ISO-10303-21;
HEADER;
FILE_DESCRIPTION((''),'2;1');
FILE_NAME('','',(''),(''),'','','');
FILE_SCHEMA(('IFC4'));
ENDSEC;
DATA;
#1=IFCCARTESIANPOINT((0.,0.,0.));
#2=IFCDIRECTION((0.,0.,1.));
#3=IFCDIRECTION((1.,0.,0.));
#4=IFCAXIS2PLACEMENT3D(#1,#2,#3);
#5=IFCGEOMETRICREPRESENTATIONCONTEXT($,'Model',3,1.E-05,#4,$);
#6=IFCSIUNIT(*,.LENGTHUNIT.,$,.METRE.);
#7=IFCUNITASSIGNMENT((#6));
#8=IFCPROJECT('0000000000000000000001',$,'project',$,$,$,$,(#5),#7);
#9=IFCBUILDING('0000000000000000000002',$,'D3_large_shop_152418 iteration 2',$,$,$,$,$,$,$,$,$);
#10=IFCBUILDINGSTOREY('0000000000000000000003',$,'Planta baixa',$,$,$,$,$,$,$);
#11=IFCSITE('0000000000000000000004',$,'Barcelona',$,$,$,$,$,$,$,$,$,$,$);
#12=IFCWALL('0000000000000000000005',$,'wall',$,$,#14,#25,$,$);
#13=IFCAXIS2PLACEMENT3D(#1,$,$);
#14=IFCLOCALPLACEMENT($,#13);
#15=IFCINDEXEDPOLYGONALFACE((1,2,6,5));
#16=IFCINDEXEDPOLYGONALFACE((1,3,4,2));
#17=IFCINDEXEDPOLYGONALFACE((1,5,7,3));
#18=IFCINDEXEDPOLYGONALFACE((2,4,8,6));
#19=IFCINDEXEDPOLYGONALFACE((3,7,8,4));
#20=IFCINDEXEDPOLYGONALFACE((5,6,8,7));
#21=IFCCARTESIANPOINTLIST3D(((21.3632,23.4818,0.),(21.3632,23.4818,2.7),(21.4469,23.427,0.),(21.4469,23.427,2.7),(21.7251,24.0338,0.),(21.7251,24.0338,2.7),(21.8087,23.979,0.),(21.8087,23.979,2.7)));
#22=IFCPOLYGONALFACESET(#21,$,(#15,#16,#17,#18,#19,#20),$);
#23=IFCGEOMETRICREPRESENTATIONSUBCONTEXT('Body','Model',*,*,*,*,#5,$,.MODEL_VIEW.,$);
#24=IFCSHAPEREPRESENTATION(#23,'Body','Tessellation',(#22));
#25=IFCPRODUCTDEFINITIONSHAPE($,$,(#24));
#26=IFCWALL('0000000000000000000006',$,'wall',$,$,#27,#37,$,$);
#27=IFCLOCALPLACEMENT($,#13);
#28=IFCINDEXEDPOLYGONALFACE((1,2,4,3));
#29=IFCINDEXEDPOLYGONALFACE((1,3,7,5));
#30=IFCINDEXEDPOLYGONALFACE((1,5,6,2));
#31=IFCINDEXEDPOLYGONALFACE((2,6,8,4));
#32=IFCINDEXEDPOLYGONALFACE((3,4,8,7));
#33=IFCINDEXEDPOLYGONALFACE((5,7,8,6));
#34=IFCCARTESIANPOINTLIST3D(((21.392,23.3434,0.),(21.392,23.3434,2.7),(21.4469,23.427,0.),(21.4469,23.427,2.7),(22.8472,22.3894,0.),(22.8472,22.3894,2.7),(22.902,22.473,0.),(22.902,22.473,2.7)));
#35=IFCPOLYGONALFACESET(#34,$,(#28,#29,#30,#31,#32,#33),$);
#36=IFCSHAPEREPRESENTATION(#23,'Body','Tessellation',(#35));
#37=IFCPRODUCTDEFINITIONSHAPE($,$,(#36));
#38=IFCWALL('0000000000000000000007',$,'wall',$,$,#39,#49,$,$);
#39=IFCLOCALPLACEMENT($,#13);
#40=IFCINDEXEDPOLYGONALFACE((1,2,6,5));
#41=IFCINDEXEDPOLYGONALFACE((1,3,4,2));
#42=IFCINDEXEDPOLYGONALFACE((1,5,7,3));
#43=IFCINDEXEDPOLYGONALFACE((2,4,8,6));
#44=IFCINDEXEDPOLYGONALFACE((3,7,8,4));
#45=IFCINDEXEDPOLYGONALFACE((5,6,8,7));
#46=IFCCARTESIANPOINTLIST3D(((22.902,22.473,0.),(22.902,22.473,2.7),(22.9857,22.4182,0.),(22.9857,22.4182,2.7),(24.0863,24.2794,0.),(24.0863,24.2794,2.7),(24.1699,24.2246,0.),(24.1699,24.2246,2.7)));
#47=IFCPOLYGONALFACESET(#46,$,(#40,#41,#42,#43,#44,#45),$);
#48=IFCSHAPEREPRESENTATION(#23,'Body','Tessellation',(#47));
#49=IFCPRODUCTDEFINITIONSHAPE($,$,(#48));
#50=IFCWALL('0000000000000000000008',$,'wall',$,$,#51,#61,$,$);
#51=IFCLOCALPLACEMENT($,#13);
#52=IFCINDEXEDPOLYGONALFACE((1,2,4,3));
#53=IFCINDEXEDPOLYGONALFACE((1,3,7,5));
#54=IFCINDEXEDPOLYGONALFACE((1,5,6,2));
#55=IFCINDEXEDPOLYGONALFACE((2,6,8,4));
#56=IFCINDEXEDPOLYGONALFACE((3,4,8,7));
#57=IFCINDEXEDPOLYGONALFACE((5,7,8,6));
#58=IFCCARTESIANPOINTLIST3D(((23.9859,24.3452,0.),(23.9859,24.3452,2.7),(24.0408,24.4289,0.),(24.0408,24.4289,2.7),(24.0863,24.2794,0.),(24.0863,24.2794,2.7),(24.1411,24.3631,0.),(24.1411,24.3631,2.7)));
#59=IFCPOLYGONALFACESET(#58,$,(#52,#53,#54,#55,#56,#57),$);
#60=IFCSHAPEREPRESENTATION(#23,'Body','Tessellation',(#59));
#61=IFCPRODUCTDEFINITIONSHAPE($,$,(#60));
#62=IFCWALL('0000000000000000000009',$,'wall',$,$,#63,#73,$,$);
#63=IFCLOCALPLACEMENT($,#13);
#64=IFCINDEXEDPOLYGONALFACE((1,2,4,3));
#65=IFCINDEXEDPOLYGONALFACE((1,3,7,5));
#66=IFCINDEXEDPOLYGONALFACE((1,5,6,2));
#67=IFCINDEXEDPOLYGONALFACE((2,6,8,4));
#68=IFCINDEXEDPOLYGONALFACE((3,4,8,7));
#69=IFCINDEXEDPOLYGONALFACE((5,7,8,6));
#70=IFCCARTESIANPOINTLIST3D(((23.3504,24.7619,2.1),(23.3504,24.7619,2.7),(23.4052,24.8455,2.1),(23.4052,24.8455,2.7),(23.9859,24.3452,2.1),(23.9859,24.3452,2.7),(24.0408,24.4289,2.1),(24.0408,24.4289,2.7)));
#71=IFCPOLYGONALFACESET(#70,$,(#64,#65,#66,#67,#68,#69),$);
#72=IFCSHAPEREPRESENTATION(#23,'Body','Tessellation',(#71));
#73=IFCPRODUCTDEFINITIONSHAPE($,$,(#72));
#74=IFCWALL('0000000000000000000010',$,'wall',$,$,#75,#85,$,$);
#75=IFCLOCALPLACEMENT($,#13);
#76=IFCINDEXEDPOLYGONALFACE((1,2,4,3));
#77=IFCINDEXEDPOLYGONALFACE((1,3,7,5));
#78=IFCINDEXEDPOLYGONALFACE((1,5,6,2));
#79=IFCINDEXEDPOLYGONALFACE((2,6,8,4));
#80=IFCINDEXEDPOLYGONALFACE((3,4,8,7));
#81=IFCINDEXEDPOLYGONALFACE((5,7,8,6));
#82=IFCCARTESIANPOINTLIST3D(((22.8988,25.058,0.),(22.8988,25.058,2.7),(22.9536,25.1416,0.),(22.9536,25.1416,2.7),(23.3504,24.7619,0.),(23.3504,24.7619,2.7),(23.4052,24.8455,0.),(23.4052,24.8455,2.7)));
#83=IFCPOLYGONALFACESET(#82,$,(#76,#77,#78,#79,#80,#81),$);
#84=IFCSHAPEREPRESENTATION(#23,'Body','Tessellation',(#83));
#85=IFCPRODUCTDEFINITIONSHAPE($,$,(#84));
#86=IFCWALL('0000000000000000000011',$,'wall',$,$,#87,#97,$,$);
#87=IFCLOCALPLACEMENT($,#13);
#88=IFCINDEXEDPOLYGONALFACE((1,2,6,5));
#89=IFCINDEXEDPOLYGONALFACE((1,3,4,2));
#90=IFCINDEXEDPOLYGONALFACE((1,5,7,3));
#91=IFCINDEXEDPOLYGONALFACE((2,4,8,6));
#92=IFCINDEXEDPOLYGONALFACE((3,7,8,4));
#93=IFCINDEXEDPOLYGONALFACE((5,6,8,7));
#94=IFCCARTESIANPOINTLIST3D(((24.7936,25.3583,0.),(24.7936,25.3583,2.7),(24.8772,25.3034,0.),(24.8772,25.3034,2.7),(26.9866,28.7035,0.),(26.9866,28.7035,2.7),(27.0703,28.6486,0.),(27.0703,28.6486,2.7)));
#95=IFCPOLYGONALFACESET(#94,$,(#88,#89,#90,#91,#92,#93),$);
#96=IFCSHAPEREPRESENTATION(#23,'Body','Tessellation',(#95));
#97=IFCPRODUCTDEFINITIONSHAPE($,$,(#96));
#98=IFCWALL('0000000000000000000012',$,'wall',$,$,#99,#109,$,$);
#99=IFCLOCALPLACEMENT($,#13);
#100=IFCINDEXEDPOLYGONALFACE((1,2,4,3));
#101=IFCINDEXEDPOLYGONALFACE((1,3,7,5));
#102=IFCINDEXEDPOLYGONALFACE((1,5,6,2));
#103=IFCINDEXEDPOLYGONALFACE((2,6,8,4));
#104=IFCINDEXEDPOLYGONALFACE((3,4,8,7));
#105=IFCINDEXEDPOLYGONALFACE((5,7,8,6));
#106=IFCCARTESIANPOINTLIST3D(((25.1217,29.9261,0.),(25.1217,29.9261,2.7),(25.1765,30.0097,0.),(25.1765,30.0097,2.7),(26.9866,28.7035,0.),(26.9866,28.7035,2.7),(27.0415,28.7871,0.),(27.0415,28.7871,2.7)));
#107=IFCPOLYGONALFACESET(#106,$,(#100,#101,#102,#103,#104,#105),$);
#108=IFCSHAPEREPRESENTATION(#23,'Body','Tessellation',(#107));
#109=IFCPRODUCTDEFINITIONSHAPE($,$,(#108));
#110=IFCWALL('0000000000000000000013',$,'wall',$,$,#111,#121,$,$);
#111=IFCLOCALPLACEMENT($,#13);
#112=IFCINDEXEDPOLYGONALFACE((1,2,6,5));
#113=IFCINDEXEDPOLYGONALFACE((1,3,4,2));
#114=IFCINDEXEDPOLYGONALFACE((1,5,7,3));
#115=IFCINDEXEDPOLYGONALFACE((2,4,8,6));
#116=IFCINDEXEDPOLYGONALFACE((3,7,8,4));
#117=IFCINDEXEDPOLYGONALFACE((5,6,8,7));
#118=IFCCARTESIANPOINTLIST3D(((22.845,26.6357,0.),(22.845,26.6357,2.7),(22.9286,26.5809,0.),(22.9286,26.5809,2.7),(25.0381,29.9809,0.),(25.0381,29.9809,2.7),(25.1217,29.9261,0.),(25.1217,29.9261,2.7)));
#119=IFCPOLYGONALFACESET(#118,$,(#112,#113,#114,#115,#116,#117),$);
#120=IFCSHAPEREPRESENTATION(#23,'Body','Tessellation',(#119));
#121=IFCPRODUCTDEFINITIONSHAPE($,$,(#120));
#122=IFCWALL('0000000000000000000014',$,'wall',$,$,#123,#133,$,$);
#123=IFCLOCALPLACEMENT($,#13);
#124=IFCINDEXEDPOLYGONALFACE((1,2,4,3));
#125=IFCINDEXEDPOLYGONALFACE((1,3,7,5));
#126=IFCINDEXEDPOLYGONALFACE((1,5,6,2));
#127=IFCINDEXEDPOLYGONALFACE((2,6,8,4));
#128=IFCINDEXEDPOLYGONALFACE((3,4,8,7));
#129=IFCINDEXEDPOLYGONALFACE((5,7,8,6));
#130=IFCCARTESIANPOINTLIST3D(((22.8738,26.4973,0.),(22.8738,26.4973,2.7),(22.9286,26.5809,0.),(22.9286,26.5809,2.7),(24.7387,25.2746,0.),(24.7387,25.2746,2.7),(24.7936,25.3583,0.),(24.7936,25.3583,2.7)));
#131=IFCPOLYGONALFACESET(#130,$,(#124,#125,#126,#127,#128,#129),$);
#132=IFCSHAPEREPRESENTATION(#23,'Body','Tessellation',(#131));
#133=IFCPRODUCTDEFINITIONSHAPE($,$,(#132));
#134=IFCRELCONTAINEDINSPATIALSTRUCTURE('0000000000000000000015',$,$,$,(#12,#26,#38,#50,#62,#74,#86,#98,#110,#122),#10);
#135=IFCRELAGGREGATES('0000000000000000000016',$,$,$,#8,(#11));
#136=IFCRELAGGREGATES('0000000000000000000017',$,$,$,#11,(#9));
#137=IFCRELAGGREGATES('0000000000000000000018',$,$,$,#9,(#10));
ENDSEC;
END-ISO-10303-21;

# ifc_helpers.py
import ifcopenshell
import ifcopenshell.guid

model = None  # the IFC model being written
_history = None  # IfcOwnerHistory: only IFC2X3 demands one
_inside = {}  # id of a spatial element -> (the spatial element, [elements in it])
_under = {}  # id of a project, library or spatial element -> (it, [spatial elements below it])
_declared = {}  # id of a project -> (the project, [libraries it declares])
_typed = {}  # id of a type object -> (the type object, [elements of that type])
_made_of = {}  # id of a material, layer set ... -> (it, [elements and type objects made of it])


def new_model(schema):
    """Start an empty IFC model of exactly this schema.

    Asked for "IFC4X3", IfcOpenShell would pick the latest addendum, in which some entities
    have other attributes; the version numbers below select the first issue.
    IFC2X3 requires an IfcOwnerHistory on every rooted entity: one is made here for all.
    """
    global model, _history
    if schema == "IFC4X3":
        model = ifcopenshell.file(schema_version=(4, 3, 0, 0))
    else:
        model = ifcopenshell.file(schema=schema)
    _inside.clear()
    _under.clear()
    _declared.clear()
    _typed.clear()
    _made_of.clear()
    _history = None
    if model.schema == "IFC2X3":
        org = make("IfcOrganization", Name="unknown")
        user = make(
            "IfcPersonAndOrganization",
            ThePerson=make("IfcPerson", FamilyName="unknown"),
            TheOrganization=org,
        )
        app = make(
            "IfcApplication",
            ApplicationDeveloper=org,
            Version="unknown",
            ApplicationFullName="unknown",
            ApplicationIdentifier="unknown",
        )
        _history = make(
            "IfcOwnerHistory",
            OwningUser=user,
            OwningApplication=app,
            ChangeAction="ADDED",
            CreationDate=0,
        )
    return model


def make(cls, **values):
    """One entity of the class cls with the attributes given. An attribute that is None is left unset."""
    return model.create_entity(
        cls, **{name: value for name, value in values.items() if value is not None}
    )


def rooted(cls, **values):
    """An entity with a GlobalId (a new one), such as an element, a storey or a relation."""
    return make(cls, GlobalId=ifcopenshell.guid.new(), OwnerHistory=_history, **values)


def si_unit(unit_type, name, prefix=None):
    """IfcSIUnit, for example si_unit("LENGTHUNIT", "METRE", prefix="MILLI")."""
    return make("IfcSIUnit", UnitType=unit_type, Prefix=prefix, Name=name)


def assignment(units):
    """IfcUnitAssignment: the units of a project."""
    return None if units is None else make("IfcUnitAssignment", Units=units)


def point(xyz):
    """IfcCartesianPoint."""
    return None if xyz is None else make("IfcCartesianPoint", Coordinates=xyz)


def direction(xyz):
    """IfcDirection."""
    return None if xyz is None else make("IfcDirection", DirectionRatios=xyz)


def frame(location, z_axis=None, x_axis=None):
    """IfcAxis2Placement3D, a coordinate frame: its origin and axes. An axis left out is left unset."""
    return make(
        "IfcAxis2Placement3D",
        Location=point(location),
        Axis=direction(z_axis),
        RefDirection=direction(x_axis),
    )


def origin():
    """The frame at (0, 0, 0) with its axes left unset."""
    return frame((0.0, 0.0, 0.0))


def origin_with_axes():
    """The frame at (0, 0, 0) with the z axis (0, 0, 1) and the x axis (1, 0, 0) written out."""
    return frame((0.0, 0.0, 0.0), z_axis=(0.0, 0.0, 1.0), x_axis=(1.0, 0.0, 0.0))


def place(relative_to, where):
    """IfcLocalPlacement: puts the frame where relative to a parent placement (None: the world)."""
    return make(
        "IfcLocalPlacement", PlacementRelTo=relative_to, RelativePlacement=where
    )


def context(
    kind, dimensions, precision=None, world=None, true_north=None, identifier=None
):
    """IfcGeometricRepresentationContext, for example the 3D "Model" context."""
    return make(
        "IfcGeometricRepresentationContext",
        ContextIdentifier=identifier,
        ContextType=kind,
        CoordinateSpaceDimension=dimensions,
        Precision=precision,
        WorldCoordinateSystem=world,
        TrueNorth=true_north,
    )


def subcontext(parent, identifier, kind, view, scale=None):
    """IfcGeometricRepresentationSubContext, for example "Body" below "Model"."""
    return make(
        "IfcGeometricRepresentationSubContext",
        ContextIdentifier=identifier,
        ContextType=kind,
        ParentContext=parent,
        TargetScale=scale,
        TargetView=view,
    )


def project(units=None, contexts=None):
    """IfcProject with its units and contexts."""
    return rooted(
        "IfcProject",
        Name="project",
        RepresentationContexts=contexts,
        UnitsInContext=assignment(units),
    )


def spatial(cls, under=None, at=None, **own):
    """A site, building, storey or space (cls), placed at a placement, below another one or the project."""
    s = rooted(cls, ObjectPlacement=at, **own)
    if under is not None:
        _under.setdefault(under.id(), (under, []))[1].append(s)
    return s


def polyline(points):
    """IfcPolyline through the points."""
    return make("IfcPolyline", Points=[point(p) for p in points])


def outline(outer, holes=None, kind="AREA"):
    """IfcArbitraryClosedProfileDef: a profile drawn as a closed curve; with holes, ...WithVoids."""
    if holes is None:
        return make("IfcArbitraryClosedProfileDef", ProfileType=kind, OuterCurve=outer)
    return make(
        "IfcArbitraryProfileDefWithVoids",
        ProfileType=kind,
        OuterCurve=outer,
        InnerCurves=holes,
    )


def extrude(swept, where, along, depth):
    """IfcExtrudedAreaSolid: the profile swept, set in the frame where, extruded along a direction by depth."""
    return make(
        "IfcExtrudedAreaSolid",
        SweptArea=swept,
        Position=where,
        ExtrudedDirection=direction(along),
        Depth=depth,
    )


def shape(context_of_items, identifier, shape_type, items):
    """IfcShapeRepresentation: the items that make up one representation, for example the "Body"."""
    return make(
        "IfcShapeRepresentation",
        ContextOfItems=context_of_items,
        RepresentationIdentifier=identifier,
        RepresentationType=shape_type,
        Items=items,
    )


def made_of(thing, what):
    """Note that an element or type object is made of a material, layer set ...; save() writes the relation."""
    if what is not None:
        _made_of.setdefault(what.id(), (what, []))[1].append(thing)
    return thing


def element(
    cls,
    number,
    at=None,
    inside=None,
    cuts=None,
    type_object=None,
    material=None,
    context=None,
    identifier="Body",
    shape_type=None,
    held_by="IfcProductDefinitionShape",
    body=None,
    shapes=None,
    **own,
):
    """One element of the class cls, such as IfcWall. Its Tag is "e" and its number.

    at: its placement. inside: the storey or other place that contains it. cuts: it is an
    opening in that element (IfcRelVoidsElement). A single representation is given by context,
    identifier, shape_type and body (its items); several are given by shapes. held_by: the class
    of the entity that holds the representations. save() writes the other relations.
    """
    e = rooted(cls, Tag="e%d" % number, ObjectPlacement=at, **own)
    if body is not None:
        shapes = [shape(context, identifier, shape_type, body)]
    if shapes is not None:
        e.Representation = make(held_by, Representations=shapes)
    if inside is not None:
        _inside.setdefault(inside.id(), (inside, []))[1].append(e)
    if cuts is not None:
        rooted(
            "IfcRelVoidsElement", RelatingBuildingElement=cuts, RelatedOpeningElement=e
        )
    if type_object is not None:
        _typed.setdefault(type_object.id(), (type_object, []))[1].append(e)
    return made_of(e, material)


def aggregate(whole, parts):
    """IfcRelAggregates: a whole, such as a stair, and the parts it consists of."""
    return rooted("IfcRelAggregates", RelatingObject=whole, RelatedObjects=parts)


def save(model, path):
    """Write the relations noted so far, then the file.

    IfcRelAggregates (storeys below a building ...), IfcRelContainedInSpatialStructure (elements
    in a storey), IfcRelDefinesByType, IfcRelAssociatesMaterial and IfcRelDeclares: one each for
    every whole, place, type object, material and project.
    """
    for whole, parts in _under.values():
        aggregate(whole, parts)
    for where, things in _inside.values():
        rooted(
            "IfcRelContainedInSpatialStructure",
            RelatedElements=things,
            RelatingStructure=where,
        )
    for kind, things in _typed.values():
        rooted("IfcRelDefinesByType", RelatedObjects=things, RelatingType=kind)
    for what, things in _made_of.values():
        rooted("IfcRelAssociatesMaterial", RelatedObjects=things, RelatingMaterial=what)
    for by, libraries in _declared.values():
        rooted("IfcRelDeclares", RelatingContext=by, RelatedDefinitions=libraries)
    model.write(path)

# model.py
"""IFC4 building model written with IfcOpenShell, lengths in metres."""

from ifc_helpers import new_model, si_unit, frame, origin, origin_with_axes, place, context, subcontext, project, spatial, polyline, outline, extrude, element, save


model = new_model("IFC4")

# Units and contexts
model_context = context("Model", 3, precision=1e-05, world=origin_with_axes())
body_context = subcontext(model_context, "Body", "Model", "MODEL_VIEW")
ifc_project = project(units=[si_unit("LENGTHUNIT", "METRE")], contexts=[model_context])

# Site, building, storey
site = spatial("IfcSite", under=ifc_project, Name="Barcelona")
building = spatial("IfcBuilding", under=site, Name="D3_large_shop_152418 iteration 2")
storey = spatial("IfcBuildingStorey", under=building, Name="Planta baixa")

# Walls
wall_1_placement = place(None, origin_with_axes())
element("IfcWall", 1, at=wall_1_placement, inside=storey, Name="wall", context=body_context, shape_type="SweptSolid", body=[
    extrude(outline(polyline([(21.8087, 23.979), (21.4469, 23.427), (21.3632, 23.4818), (21.7251, 24.0338), (21.8087, 23.979)])), origin(), (0.0, 0.0, 1.0), 2.7),
])
wall_2_placement = place(None, origin_with_axes())
element("IfcWall", 2, at=wall_2_placement, inside=storey, Name="wall", context=body_context, shape_type="SweptSolid", body=[
    extrude(outline(polyline([(21.4469, 23.427), (22.902, 22.473), (22.8472, 22.3894), (21.392, 23.3434), (21.4469, 23.427)])), origin(), (0.0, 0.0, 1.0), 2.7),
])
wall_3_placement = place(None, origin_with_axes())
element("IfcWall", 3, at=wall_3_placement, inside=storey, Name="wall", context=body_context, shape_type="SweptSolid", body=[
    extrude(outline(polyline([(22.902, 22.473), (24.0863, 24.2794), (24.1699, 24.2246), (22.9857, 22.4182), (22.902, 22.473)])), origin(), (0.0, 0.0, 1.0), 2.7),
])
wall_4_placement = place(None, origin_with_axes())
element("IfcWall", 4, at=wall_4_placement, inside=storey, Name="wall", context=body_context, shape_type="SweptSolid", body=[
    extrude(outline(polyline([(24.0863, 24.2794), (23.9859, 24.3452), (24.0408, 24.4289), (24.1411, 24.3631), (24.0863, 24.2794)])), origin(), (0.0, 0.0, 1.0), 2.7),
])
wall_5_placement = place(None, origin_with_axes())
element("IfcWall", 5, at=wall_5_placement, inside=storey, Name="wall", context=body_context, shape_type="SweptSolid", body=[
    extrude(outline(polyline([(23.9859, 24.3452), (23.3504, 24.7619), (23.4052, 24.8455), (24.0408, 24.4289), (23.9859, 24.3452)])), frame((0.0, 0.0, 2.1)), (0.0, 0.0, 1.0), 0.6),
])
wall_6_placement = place(None, origin_with_axes())
element("IfcWall", 6, at=wall_6_placement, inside=storey, Name="wall", context=body_context, shape_type="SweptSolid", body=[
    extrude(outline(polyline([(23.3504, 24.7619), (22.8988, 25.058), (22.9536, 25.1416), (23.4052, 24.8455), (23.3504, 24.7619)])), origin(), (0.0, 0.0, 1.0), 2.7),
])
wall_7_placement = place(None, origin_with_axes())
element("IfcWall", 7, at=wall_7_placement, inside=storey, Name="wall", context=body_context, shape_type="SweptSolid", body=[
    extrude(outline(polyline([(24.7936, 25.3583), (26.9866, 28.7035), (27.0703, 28.6486), (24.8772, 25.3034), (24.7936, 25.3583)])), origin(), (0.0, 0.0, 1.0), 2.7),
])
wall_8_placement = place(None, origin_with_axes())
element("IfcWall", 8, at=wall_8_placement, inside=storey, Name="wall", context=body_context, shape_type="SweptSolid", body=[
    extrude(outline(polyline([(26.9866, 28.7035), (25.1217, 29.9261), (25.1765, 30.0097), (27.0415, 28.7871), (26.9866, 28.7035)])), origin(), (0.0, 0.0, 1.0), 2.7),
])
wall_9_placement = place(None, origin_with_axes())
element("IfcWall", 9, at=wall_9_placement, inside=storey, Name="wall", context=body_context, shape_type="SweptSolid", body=[
    extrude(outline(polyline([(25.1217, 29.9261), (22.9286, 26.5809), (22.845, 26.6357), (25.0381, 29.9809), (25.1217, 29.9261)])), origin(), (0.0, 0.0, 1.0), 2.7),
])
wall_10_placement = place(None, origin_with_axes())
element("IfcWall", 10, at=wall_10_placement, inside=storey, Name="wall", context=body_context, shape_type="SweptSolid", body=[
    extrude(outline(polyline([(22.9286, 26.5809), (24.7936, 25.3583), (24.7387, 25.2746), (22.8738, 26.4973), (22.9286, 26.5809)])), origin(), (0.0, 0.0, 1.0), 2.7),
])

save(model, "model.ifc")
